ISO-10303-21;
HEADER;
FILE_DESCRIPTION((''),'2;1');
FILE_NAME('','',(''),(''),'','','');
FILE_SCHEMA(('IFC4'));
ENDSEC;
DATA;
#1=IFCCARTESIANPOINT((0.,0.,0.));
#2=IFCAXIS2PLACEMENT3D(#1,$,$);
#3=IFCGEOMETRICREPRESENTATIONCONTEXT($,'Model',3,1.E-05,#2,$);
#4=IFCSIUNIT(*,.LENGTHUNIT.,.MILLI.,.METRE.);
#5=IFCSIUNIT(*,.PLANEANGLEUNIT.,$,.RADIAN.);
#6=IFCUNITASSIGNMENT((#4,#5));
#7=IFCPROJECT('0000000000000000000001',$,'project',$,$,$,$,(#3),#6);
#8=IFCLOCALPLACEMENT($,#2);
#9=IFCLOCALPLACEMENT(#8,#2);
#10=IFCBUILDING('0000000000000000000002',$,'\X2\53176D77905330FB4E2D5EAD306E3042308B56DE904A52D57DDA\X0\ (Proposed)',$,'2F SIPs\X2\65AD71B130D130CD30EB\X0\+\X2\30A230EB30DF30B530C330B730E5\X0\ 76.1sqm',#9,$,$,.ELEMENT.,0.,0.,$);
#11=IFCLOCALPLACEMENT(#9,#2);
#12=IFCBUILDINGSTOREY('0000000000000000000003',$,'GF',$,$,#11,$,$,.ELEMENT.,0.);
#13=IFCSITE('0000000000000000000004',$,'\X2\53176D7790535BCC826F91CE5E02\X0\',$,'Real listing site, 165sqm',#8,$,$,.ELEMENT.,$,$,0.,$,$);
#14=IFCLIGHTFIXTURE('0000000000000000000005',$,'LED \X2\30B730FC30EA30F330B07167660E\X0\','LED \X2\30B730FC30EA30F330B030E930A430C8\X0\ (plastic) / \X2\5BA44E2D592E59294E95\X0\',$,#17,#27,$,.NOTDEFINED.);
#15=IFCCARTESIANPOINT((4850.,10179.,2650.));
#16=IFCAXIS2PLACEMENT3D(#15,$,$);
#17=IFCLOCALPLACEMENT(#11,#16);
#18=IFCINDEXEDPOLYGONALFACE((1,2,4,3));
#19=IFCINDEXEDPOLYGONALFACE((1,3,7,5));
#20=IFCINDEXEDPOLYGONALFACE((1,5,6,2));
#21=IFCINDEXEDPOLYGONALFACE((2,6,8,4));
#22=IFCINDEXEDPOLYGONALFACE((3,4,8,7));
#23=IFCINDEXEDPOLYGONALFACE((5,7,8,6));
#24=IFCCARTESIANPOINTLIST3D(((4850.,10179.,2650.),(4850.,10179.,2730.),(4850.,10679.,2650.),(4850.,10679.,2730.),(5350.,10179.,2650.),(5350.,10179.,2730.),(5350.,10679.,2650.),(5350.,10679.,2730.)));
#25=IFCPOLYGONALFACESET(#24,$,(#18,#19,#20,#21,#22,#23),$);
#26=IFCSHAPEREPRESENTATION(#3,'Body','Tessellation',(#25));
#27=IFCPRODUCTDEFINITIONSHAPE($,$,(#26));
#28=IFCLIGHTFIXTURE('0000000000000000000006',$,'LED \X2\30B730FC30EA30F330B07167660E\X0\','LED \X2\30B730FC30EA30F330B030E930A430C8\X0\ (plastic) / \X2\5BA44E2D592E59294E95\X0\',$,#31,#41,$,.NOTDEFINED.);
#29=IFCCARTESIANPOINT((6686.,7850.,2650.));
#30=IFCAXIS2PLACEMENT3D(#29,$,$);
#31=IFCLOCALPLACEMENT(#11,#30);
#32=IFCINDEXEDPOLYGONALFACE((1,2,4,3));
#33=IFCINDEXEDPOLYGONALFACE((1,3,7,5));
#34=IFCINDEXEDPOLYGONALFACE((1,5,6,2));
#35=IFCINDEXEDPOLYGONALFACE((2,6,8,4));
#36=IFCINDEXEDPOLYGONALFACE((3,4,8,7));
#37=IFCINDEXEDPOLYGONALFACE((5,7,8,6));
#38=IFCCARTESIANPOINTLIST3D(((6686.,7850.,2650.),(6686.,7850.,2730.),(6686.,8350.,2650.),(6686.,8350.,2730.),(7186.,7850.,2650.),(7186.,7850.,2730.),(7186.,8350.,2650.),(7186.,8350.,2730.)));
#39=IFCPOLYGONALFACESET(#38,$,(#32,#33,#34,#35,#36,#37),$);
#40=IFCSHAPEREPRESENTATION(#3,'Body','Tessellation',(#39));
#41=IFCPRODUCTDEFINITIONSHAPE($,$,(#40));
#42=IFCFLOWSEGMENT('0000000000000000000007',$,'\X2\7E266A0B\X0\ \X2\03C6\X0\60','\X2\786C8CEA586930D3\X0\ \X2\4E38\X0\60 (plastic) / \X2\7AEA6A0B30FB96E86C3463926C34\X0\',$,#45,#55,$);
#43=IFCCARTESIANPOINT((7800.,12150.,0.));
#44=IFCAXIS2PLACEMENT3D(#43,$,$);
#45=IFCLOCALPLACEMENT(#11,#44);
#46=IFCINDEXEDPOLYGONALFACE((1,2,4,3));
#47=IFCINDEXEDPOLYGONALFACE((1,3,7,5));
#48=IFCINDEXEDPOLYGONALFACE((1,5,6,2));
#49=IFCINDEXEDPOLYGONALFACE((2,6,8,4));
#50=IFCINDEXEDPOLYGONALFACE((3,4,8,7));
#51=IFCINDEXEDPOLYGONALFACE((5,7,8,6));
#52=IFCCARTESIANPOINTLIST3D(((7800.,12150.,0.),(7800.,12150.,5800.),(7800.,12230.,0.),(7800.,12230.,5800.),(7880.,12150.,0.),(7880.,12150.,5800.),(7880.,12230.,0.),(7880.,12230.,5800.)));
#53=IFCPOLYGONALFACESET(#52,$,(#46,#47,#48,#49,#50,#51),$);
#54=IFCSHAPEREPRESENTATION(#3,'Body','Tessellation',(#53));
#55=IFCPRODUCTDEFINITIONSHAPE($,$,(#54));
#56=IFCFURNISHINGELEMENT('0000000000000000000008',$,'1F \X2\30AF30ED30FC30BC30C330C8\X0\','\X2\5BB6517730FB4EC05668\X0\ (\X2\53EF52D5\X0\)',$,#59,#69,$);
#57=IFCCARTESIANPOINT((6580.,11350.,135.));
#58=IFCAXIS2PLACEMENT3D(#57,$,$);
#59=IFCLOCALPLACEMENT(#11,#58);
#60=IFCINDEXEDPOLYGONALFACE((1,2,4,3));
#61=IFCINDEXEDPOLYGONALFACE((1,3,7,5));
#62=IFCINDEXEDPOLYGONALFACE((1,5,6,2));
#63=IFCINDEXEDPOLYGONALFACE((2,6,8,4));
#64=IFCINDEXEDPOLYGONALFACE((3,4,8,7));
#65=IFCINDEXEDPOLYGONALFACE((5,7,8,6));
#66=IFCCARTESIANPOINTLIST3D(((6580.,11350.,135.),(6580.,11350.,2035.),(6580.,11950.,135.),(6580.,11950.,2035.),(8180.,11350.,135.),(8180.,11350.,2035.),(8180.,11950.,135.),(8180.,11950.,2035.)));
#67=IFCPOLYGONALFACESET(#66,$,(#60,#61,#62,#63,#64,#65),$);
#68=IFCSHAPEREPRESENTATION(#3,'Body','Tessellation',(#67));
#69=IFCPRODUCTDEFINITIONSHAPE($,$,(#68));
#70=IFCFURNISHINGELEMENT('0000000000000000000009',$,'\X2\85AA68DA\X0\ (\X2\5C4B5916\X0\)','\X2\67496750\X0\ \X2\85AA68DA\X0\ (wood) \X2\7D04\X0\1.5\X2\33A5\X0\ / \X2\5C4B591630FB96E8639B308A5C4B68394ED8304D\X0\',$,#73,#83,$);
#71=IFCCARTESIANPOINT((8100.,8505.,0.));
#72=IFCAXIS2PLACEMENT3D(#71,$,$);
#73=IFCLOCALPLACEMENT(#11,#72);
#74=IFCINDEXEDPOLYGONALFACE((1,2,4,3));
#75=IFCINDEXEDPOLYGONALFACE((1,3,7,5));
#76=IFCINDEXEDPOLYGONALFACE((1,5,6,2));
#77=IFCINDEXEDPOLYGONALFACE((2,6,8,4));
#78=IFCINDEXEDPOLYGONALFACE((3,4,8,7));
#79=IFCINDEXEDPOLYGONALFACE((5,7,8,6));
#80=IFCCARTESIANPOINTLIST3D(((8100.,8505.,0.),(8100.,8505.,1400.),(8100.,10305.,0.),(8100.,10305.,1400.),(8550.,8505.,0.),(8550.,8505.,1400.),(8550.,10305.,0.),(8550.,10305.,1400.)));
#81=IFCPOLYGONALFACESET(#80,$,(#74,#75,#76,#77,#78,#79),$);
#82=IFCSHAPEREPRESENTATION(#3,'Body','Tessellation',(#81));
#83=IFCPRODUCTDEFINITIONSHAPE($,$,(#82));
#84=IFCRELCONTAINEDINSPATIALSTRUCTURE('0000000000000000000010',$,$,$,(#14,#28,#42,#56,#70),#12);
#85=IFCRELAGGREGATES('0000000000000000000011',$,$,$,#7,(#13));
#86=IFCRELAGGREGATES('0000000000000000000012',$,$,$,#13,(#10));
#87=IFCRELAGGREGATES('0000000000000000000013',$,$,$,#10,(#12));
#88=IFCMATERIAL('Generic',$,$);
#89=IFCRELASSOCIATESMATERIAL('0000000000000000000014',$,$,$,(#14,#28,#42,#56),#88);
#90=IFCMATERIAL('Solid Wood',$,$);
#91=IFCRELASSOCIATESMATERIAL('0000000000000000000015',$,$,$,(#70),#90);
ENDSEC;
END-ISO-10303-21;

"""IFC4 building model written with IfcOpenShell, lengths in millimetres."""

from ifc_helpers import new_model, si_unit, frame, frame_2d, origin, place, context, project, spatial, rectangle, extrude, material, element, save


model = new_model("IFC4")

# Units and contexts
model_context = context("Model", 3, precision=1e-05, world=origin())
ifc_project = project(units=[si_unit("LENGTHUNIT", "METRE", prefix="MILLI"), si_unit("PLANEANGLEUNIT", "RADIAN")], contexts=[model_context])

# Site, building, storey
site_placement = place(None, origin())
site = spatial("IfcSite", under=ifc_project, at=site_placement, Name="北海道富良野市", ObjectType="Real listing site, 165sqm", CompositionType="ELEMENT", RefElevation=0.0)
building_placement = place(site_placement, origin())
building = spatial("IfcBuilding", under=site, at=building_placement, Name="北海道・中庭のある回遊動線 (Proposed)", ObjectType="2F SIPs断熱パネル+アルミサッシュ 76.1sqm", CompositionType="ELEMENT", ElevationOfRefHeight=0.0, ElevationOfTerrain=0.0)
storey_placement = place(building_placement, origin())
storey = spatial("IfcBuildingStorey", under=building, at=storey_placement, Name="GF", CompositionType="ELEMENT", Elevation=0.0)

# Shared definitions
ifc_material_1 = material(Name="Solid Wood")

# Shared definitions
ifc_material_2 = material(Name="Generic")

# Light fixtures
light_fixture_1_placement = place(storey_placement, frame((4850.0, 10179.0, 2650.0)))
element("IfcLightFixture", 1, at=light_fixture_1_placement, inside=storey, material=ifc_material_2, Name="LED シーリング照明", Description="LED シーリングライト (plastic) / 室中央天井", PredefinedType="NOTDEFINED", context=model_context, shape_type="SweptSolid", body=[
    extrude(rectangle(XDim=500.0, YDim=500.0, at=frame_2d((250.0, 250.0))), frame((4850.0, 10179.0, 2650.0)), (0.0, 0.0, 1.0), 80.0),
])
light_fixture_2_placement = place(storey_placement, frame((6686.0, 7850.0, 2650.0)))
element("IfcLightFixture", 2, at=light_fixture_2_placement, inside=storey, material=ifc_material_2, Name="LED シーリング照明", Description="LED シーリングライト (plastic) / 室中央天井", PredefinedType="NOTDEFINED", context=model_context, shape_type="SweptSolid", body=[
    extrude(rectangle(XDim=500.0, YDim=500.0, at=frame_2d((250.0, 250.0))), frame((6686.0, 7850.0, 2650.0)), (0.0, 0.0, 1.0), 80.0),
])

# Flow segment
flow_segment_placement = place(storey_placement, frame((7800.0, 12150.0, 0.0)))
element("IfcFlowSegment", 3, at=flow_segment_placement, inside=storey, material=ifc_material_2, Name="縦樋 φ60", Description="硬質塩ビ 丸60 (plastic) / 竪樋・雨水排水", context=model_context, shape_type="SweptSolid", body=[
    extrude(rectangle(XDim=80.0, YDim=80.0, at=frame_2d((40.0, 40.0))), frame((7800.0, 12150.0, 0.0)), (0.0, 0.0, 1.0), 5800.0),
])

# Furnishing elements
furnishing_1_placement = place(storey_placement, frame((6580.0, 11350.0, 135.0)))
element("IfcFurnishingElement", 4, at=furnishing_1_placement, inside=storey, material=ifc_material_2, Name="1F クローゼット", Description="家具・什器 (可動)", context=model_context, shape_type="SweptSolid", body=[
    extrude(rectangle(XDim=1600.0, YDim=600.0, at=frame_2d((800.0, 300.0))), frame((6580.0, 11350.0, 135.0)), (0.0, 0.0, 1.0), 1900.0),
])
furnishing_2_placement = place(storey_placement, frame((8100.0, 8505.0, 0.0)))
element("IfcFurnishingElement", 5, at=furnishing_2_placement, inside=storey, material=ifc_material_1, Name="薪棚 (屋外)", Description="杉材 薪棚 (wood) 約1.5㎥ / 屋外・雨掛り屋根付き", context=model_context, shape_type="SweptSolid", body=[
    extrude(rectangle(XDim=450.0, YDim=1800.0, at=frame_2d((225.0, 900.0))), frame((8100.0, 8505.0, 0.0)), (0.0, 0.0, 1.0), 1400.0),
])

save(model, "model.ifc")
